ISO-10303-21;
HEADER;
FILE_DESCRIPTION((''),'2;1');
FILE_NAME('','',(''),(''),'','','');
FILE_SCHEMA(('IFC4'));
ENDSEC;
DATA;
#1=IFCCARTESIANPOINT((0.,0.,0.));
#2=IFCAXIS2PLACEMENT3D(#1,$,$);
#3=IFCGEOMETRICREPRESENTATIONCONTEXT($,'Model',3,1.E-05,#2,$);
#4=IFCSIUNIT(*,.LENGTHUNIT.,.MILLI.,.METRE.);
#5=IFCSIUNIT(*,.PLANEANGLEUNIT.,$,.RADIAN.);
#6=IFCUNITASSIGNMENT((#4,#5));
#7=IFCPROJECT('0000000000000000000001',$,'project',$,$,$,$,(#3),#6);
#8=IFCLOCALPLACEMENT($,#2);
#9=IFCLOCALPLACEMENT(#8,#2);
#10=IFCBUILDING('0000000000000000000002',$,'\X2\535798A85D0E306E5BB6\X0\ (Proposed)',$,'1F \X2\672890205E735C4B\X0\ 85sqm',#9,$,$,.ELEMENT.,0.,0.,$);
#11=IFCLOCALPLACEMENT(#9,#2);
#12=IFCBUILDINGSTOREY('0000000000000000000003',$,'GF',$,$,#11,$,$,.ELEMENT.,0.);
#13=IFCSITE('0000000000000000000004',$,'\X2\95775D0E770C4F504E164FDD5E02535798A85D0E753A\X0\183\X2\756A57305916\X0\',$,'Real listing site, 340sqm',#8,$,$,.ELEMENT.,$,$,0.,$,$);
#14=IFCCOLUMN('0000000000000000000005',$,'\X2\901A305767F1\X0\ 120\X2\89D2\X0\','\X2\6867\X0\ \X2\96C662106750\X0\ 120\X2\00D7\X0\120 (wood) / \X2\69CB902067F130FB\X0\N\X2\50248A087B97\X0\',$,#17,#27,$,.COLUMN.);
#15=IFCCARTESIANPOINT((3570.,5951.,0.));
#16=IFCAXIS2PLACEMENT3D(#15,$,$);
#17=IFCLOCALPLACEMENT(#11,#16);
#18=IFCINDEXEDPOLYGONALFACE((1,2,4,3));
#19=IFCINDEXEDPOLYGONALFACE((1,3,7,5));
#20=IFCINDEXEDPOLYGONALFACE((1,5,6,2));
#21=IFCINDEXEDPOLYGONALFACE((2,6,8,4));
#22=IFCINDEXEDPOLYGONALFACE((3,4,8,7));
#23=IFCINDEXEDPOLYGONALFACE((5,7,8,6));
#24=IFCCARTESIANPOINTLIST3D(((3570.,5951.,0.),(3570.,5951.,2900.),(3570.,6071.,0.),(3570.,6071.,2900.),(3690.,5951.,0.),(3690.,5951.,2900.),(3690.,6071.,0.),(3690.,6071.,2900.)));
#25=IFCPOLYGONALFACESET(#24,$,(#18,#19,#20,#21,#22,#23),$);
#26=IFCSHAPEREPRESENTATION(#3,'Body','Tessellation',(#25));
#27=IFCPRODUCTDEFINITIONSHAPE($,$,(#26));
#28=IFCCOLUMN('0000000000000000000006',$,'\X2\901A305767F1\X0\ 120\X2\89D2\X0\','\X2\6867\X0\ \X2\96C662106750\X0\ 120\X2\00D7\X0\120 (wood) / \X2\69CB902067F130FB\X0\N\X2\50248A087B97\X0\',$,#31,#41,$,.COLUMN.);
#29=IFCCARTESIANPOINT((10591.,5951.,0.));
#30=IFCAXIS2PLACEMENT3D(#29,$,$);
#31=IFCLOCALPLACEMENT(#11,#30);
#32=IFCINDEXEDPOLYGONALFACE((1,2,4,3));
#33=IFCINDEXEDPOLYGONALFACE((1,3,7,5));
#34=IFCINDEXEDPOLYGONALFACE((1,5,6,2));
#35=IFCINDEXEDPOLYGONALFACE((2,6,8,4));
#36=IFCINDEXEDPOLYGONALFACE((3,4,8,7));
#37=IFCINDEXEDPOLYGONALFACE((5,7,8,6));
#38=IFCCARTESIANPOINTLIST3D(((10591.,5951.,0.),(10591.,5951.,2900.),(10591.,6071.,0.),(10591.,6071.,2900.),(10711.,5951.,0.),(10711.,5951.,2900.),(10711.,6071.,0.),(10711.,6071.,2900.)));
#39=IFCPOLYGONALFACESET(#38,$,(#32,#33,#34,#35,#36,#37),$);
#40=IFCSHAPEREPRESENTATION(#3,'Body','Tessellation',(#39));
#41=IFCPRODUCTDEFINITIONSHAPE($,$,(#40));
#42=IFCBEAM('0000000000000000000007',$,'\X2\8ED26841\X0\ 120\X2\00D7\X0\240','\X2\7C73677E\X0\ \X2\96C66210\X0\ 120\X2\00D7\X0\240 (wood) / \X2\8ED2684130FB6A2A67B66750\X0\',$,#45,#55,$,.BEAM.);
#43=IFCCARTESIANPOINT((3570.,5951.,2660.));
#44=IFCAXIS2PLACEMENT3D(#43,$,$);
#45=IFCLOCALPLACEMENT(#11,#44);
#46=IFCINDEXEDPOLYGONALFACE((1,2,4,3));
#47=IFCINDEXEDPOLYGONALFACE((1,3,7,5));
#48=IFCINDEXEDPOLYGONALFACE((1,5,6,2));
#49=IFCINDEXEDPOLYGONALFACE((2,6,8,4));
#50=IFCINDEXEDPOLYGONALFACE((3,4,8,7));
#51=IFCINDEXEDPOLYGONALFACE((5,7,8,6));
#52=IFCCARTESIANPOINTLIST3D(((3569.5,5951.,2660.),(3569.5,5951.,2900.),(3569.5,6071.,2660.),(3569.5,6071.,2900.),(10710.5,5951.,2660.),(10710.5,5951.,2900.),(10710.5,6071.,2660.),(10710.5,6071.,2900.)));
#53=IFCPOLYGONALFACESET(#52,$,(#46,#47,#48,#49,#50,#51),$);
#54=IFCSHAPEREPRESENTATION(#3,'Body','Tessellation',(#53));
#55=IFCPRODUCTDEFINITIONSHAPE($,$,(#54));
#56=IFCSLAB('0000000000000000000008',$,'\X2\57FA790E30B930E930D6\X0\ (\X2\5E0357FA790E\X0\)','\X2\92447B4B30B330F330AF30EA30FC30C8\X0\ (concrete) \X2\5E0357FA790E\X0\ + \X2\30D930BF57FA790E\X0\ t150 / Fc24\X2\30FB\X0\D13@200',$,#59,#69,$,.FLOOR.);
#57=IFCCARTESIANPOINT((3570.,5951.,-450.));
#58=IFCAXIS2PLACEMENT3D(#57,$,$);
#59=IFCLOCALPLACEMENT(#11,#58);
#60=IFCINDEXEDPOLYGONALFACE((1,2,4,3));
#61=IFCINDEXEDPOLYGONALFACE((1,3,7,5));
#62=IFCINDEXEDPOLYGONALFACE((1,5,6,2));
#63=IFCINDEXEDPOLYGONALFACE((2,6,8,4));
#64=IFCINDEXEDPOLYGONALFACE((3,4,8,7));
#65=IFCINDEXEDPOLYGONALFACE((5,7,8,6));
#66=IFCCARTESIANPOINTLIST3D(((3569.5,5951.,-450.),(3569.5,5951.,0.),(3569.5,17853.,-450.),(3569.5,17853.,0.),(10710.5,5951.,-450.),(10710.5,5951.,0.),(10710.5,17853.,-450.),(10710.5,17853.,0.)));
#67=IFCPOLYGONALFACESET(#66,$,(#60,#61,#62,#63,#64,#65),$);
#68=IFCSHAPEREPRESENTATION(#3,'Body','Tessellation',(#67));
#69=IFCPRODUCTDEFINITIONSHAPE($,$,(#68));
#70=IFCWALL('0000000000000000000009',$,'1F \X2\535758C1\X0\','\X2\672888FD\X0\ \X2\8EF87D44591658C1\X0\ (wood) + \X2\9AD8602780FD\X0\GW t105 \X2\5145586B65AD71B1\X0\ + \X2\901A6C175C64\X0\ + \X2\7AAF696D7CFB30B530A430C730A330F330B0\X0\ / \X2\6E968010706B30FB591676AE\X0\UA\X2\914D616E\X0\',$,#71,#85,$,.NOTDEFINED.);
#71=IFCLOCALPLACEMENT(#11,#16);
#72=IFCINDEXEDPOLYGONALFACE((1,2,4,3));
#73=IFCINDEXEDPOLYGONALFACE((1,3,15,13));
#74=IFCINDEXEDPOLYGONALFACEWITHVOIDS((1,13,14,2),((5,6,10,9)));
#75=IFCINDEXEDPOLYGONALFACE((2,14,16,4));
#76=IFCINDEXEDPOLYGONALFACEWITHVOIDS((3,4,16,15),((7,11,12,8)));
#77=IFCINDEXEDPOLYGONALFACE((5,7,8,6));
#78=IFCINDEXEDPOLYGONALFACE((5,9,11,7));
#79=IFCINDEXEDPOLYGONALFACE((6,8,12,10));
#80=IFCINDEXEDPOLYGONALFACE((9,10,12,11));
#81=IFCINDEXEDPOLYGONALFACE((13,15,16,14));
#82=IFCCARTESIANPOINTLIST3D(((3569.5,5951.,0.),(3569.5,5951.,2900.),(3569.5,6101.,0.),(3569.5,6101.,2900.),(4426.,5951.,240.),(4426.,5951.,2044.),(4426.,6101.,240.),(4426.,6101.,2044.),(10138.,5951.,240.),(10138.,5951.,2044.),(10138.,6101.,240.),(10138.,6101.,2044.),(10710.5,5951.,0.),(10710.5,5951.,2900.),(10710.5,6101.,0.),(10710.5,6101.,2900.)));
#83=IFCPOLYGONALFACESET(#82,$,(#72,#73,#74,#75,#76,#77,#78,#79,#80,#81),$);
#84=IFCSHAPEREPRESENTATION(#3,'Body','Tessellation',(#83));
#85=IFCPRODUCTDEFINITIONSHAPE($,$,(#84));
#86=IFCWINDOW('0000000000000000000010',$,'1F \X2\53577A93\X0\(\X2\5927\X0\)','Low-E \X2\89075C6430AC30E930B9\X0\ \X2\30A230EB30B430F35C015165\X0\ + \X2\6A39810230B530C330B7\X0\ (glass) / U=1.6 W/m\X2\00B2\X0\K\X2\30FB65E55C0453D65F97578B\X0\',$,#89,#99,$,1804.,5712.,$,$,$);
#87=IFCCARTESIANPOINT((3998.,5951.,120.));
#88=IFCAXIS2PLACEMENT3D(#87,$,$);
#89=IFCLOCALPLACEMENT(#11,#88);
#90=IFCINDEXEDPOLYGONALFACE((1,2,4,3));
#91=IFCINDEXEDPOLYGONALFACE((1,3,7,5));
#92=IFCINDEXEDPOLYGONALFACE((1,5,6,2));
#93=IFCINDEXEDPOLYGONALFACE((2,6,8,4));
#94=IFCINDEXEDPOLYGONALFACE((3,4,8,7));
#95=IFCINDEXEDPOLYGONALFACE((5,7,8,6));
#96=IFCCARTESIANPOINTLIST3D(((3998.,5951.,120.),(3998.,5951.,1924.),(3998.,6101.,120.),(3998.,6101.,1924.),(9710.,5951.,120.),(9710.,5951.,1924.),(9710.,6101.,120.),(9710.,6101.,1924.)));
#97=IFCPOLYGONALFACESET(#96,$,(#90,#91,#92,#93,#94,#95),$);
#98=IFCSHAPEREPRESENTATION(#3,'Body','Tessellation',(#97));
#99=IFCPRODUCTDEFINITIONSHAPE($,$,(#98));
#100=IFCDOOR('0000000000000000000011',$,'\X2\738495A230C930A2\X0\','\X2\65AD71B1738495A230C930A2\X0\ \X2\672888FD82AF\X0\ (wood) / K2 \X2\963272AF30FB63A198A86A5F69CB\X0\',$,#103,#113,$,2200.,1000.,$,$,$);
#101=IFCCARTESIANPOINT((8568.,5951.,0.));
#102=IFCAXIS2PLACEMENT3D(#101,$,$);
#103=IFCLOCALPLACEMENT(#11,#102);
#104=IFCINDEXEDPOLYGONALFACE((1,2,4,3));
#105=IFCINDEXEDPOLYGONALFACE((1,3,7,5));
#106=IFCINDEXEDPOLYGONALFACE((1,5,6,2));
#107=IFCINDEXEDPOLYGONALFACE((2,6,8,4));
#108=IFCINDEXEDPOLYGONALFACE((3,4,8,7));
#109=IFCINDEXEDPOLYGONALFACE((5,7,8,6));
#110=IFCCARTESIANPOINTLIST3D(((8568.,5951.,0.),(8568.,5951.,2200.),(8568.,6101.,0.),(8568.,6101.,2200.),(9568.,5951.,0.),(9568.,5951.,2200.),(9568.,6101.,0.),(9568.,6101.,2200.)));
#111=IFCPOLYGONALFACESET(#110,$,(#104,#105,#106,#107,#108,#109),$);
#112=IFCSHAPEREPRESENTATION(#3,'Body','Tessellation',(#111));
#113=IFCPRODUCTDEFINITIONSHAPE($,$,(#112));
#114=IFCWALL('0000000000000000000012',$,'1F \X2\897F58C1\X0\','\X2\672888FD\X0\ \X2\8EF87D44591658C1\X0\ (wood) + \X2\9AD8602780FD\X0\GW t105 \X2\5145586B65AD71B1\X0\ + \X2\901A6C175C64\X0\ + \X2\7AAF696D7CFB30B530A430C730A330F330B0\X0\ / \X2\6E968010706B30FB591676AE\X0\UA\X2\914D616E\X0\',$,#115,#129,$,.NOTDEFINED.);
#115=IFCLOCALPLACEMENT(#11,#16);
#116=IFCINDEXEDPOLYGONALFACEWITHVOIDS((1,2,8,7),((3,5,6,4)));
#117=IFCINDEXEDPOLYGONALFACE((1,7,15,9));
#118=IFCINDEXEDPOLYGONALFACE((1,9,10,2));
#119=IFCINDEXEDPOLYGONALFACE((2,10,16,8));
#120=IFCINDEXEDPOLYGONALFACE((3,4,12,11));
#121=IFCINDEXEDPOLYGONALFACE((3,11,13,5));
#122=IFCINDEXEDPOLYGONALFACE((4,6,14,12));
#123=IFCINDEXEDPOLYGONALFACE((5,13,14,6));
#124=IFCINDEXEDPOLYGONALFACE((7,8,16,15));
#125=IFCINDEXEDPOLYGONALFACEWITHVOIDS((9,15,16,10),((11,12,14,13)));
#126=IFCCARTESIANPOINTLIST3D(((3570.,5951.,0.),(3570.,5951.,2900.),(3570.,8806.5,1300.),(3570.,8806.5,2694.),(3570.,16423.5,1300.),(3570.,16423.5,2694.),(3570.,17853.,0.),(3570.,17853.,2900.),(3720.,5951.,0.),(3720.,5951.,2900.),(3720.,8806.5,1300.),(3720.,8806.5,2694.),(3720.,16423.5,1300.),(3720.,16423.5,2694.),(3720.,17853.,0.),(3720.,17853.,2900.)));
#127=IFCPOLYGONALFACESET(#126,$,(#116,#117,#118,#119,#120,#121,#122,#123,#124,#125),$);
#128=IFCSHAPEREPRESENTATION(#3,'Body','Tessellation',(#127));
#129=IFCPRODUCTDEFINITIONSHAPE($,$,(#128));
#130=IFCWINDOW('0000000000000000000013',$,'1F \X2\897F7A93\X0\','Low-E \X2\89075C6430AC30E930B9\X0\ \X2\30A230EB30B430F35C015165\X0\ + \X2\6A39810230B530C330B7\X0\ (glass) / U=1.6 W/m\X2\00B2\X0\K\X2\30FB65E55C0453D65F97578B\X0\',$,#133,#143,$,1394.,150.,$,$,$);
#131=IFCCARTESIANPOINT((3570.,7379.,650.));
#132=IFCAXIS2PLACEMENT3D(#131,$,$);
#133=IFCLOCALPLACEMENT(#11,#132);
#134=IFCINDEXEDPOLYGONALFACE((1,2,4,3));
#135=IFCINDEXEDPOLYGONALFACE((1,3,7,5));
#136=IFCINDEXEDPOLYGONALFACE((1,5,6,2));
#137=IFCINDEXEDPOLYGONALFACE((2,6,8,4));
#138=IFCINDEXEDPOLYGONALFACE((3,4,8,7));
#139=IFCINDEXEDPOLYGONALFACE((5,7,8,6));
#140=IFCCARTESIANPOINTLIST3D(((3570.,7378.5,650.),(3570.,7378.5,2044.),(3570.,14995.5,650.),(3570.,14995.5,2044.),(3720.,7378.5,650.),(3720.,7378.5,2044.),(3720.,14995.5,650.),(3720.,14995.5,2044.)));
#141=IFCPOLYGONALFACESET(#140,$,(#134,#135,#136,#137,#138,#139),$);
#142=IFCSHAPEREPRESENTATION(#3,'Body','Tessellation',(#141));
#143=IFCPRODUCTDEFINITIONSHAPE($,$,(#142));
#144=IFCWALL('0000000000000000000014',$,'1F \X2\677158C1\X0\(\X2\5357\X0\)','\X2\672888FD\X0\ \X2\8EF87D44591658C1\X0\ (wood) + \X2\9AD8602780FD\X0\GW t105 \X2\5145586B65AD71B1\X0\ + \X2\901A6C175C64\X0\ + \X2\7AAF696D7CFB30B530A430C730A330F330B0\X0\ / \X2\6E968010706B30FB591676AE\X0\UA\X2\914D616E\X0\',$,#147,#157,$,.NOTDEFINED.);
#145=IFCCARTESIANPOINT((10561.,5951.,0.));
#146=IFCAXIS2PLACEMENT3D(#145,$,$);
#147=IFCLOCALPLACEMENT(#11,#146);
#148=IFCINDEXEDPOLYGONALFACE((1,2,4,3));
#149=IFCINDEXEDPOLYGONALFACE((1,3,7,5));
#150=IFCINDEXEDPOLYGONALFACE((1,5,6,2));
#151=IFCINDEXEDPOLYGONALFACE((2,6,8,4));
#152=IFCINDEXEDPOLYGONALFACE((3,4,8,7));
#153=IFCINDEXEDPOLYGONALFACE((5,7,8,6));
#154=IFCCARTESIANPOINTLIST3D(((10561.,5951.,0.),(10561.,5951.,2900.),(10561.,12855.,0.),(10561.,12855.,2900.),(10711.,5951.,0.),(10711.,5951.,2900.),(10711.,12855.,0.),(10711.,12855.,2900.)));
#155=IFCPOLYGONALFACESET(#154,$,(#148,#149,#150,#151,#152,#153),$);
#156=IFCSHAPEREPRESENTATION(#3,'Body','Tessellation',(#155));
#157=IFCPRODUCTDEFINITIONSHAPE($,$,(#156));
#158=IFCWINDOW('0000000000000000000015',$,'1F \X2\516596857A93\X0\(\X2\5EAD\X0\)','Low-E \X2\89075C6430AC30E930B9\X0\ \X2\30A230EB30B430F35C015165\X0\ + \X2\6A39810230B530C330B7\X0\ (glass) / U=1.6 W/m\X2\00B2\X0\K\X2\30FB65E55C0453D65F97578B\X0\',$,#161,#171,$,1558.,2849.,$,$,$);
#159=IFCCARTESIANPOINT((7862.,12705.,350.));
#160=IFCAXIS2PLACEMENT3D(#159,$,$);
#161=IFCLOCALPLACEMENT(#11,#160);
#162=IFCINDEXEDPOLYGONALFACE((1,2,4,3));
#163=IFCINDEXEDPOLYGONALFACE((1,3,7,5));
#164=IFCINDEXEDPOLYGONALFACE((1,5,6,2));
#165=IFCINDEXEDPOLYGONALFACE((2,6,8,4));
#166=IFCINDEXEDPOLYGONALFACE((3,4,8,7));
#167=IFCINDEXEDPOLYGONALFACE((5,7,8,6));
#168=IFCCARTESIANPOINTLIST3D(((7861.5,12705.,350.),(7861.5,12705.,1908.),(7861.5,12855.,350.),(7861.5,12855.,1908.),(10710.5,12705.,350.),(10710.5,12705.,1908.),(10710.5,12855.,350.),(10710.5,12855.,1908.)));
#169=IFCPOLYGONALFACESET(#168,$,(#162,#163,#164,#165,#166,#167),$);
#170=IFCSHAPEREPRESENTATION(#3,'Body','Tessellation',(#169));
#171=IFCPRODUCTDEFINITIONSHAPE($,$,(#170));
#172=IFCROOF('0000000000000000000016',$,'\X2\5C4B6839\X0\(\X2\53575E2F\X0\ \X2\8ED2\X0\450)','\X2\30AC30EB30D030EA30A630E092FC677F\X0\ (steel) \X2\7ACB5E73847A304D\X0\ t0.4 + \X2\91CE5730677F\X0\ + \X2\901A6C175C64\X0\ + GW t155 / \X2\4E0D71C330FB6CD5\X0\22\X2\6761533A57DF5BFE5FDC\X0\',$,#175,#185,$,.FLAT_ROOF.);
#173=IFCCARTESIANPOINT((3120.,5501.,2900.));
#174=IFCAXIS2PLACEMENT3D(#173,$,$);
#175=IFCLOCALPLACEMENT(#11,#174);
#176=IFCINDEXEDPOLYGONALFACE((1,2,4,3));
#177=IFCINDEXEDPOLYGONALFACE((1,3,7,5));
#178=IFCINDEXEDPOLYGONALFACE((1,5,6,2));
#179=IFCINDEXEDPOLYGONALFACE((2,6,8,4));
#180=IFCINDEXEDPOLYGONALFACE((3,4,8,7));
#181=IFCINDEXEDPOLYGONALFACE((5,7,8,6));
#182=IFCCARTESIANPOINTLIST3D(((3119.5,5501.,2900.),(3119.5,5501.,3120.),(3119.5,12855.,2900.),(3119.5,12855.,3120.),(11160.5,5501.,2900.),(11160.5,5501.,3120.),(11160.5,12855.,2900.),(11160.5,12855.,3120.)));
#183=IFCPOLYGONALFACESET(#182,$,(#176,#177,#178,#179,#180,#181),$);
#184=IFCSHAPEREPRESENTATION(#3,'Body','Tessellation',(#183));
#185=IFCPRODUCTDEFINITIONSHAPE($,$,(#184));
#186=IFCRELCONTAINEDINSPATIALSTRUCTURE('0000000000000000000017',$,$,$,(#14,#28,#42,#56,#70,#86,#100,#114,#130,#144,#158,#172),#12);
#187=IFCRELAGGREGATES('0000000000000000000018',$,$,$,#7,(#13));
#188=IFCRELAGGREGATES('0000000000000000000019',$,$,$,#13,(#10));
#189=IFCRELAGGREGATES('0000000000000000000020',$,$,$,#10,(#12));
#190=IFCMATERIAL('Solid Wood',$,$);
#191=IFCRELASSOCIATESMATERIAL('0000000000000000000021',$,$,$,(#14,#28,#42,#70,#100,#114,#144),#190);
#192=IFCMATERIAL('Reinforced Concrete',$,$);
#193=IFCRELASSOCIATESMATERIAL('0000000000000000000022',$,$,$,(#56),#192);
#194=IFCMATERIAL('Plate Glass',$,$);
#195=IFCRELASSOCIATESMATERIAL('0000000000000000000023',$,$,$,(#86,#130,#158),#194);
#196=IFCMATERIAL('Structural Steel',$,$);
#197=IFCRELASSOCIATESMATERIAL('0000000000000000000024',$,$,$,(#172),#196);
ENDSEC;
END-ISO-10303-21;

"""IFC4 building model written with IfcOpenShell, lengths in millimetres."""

from ifc_helpers import new_model, si_unit, frame, frame_2d, origin, place, context, project, spatial, rectangle, extrude, material, element, fill, save


model = new_model("IFC4")

# Units and contexts
model_context = context("Model", 3, precision=1e-05, world=origin())
ifc_project = project(units=[si_unit("LENGTHUNIT", "METRE", prefix="MILLI"), si_unit("PLANEANGLEUNIT", "RADIAN")], contexts=[model_context])

# Site, building, storey
site_placement = place(None, origin())
site = spatial("IfcSite", under=ifc_project, at=site_placement, Name="長崎県佐世保市南風崎町183番地外", ObjectType="Real listing site, 340sqm", CompositionType="ELEMENT", RefElevation=0.0)
building_placement = place(site_placement, origin())
building = spatial("IfcBuilding", under=site, at=building_placement, Name="南風崎の家 (Proposed)", ObjectType="1F 木造平屋 85sqm", CompositionType="ELEMENT", ElevationOfRefHeight=0.0, ElevationOfTerrain=0.0)
storey_placement = place(building_placement, origin())
storey = spatial("IfcBuildingStorey", under=building, at=storey_placement, Name="GF", CompositionType="ELEMENT", Elevation=0.0)

# Columns
ifc_material_1 = material(Name="Solid Wood")
column_1_placement = place(storey_placement, frame((3570.0, 5951.0, 0.0)))
element("IfcColumn", 1, at=column_1_placement, inside=storey, material=ifc_material_1, Name="通し柱 120角", Description="桧 集成材 120×120 (wood) / 構造柱・N値計算", PredefinedType="COLUMN", context=model_context, shape_type="SweptSolid", body=[
    extrude(rectangle(XDim=120.0, YDim=120.0, at=frame_2d((60.0, 60.0))), frame((3570.0, 5951.0, 0.0)), (0.0, 0.0, 1.0), 2900.0),
])
column_2_placement = place(storey_placement, frame((10591.0, 5951.0, 0.0)))
element("IfcColumn", 2, at=column_2_placement, inside=storey, material=ifc_material_1, Name="通し柱 120角", Description="桧 集成材 120×120 (wood) / 構造柱・N値計算", PredefinedType="COLUMN", context=model_context, shape_type="SweptSolid", body=[
    extrude(rectangle(XDim=120.0, YDim=120.0, at=frame_2d((60.0, 60.0))), frame((10591.0, 5951.0, 0.0)), (0.0, 0.0, 1.0), 2900.0),
])

# Beam
beam_1_placement = place(storey_placement, frame((3570.0, 5951.0, 2660.0)))
element("IfcBeam", 3, at=beam_1_placement, inside=storey, material=ifc_material_1, Name="軒桁 120×240", Description="米松 集成 120×240 (wood) / 軒桁・横架材", PredefinedType="BEAM", context=model_context, shape_type="SweptSolid", body=[
    extrude(rectangle(XDim=7141.0, YDim=120.0, at=frame_2d((3570.0, 60.0))), frame((3570.0, 5951.0, 2660.0)), (0.0, 0.0, 1.0), 240.0),
])

# Slab
ifc_material_2 = material(Name="Reinforced Concrete")
slab_1_placement = place(storey_placement, frame((3570.0, 5951.0, -450.0)))
element("IfcSlab", 4, at=slab_1_placement, inside=storey, material=ifc_material_2, Name="基礎スラブ (布基礎)", Description="鉄筋コンクリート (concrete) 布基礎 + ベタ基礎 t150 / Fc24・D13@200", PredefinedType="FLOOR", context=model_context, shape_type="SweptSolid", body=[
    extrude(rectangle(XDim=7141.0, YDim=11902.0, at=frame_2d((3570.0, 5951.0))), frame((3570.0, 5951.0, -450.0)), (0.0, 0.0, 1.0), 450.0),
])

# Wall, openings, window, door
wall_1_placement = place(storey_placement, frame((3570.0, 5951.0, 0.0)))
wall_1 = element("IfcWall", 5, at=wall_1_placement, inside=storey, material=ifc_material_1, Name="1F 南壁", Description="木製 軸組外壁 (wood) + 高性能GW t105 充填断熱 + 通気層 + 窯業系サイディング / 準耐火・外皮UA配慮", PredefinedType="NOTDEFINED", context=model_context, shape_type="SweptSolid", body=[
    extrude(rectangle(XDim=7141.0, YDim=150.0, at=frame_2d((3570.0, 75.0))), frame((3570.0, 5951.0, 0.0)), (0.0, 0.0, 1.0), 2900.0),
])
opening_1_placement = place(storey_placement, frame((3998.0, 5951.0, 120.0)))
opening_1 = element("IfcOpeningElement", 6, at=opening_1_placement, cuts=wall_1, PredefinedType="NOTDEFINED", context=model_context, shape_type="SweptSolid", body=[
    extrude(rectangle(XDim=5712.0, YDim=150.0, at=frame_2d((2856.0, 75.0))), frame((3998.0, 5951.0, 120.0)), (0.0, 0.0, 1.0), 1804.0),
])
opening_2_placement = place(storey_placement, frame((8568.0, 5951.0, 0.0)))
opening_2 = element("IfcOpeningElement", 7, at=opening_2_placement, cuts=wall_1, PredefinedType="NOTDEFINED", context=model_context, shape_type="SweptSolid", body=[
    extrude(rectangle(XDim=1000.0, YDim=150.0, at=frame_2d((500.0, 75.0))), frame((8568.0, 5951.0, 0.0)), (0.0, 0.0, 1.0), 2200.0),
])
ifc_material_3 = material(Name="Plate Glass")
window_1_placement = place(storey_placement, frame((3998.0, 5951.0, 120.0)))
window_1 = element("IfcWindow", 8, at=window_1_placement, inside=storey, material=ifc_material_3, Name="1F 南窓(大)", Description="Low-E 複層ガラス アルゴン封入 + 樹脂サッシ (glass) / U=1.6 W/m²K・日射取得型", OverallHeight=1804.0, OverallWidth=5712.0, context=model_context, shape_type="SweptSolid", body=[
    extrude(rectangle(XDim=5712.0, YDim=150.0, at=frame_2d((2856.0, 75.0))), frame((3998.0, 5951.0, 120.0)), (0.0, 0.0, 1.0), 1804.0),
])
fill(opening_1, window_1)
door_1_placement = place(storey_placement, frame((8568.0, 5951.0, 0.0)))
door_1 = element("IfcDoor", 9, at=door_1_placement, inside=storey, material=ifc_material_1, Name="玄関ドア", Description="断熱玄関ドア 木製芯 (wood) / K2 防犯・採風機構", OverallHeight=2200.0, OverallWidth=1000.0, context=model_context, shape_type="SweptSolid", body=[
    extrude(rectangle(XDim=1000.0, YDim=150.0, at=frame_2d((500.0, 75.0))), frame((8568.0, 5951.0, 0.0)), (0.0, 0.0, 1.0), 2200.0),
])
fill(opening_2, door_1)

# Walls, openings, windows
wall_2_placement = place(storey_placement, frame((3570.0, 5951.0, 0.0)))
wall_2 = element("IfcWall", 10, at=wall_2_placement, inside=storey, material=ifc_material_1, Name="1F 西壁", Description="木製 軸組外壁 (wood) + 高性能GW t105 充填断熱 + 通気層 + 窯業系サイディング / 準耐火・外皮UA配慮", PredefinedType="NOTDEFINED", context=model_context, shape_type="SweptSolid", body=[
    extrude(rectangle(XDim=150.0, YDim=11902.0, at=frame_2d((75.0, 5951.0))), frame((3570.0, 5951.0, 0.0)), (0.0, 0.0, 1.0), 2900.0),
])
opening_3_placement = place(storey_placement, frame((3570.0, 7379.0, 650.0)))
opening_3 = element("IfcOpeningElement", 11, at=opening_3_placement, cuts=wall_2, PredefinedType="NOTDEFINED", context=model_context, shape_type="SweptSolid", body=[
    extrude(rectangle(XDim=150.0, YDim=7617.0, at=frame_2d((75.0, 3808.0))), frame((3570.0, 7379.0, 650.0)), (0.0, 0.0, 1.0), 1394.0),
])
window_2_placement = place(storey_placement, frame((3570.0, 7379.0, 650.0)))
window_2 = element("IfcWindow", 12, at=window_2_placement, inside=storey, material=ifc_material_3, Name="1F 西窓", Description="Low-E 複層ガラス アルゴン封入 + 樹脂サッシ (glass) / U=1.6 W/m²K・日射取得型", OverallHeight=1394.0, OverallWidth=150.0, context=model_context, shape_type="SweptSolid", body=[
    extrude(rectangle(XDim=150.0, YDim=7617.0, at=frame_2d((75.0, 3808.0))), frame((3570.0, 7379.0, 650.0)), (0.0, 0.0, 1.0), 1394.0),
])
fill(opening_3, window_2)
wall_3_placement = place(storey_placement, frame((10561.0, 5951.0, 0.0)))
wall_3 = element("IfcWall", 13, at=wall_3_placement, inside=storey, material=ifc_material_1, Name="1F 東壁(南)", Description="木製 軸組外壁 (wood) + 高性能GW t105 充填断熱 + 通気層 + 窯業系サイディング / 準耐火・外皮UA配慮", PredefinedType="NOTDEFINED", context=model_context, shape_type="SweptSolid", body=[
    extrude(rectangle(XDim=150.0, YDim=6904.0, at=frame_2d((75.0, 3452.0))), frame((10561.0, 5951.0, 0.0)), (0.0, 0.0, 1.0), 2900.0),
])
opening_4_placement = place(storey_placement, frame((7862.0, 12705.0, 350.0)))
opening_4 = element("IfcOpeningElement", 14, at=opening_4_placement, cuts=wall_3, PredefinedType="NOTDEFINED", context=model_context, shape_type="SweptSolid", body=[
    extrude(rectangle(XDim=2849.0, YDim=150.0, at=frame_2d((1424.0, 75.0))), frame((7862.0, 12705.0, 350.0)), (0.0, 0.0, 1.0), 1558.0),
])
window_3_placement = place(storey_placement, frame((7862.0, 12705.0, 350.0)))
window_3 = element("IfcWindow", 15, at=window_3_placement, inside=storey, material=ifc_material_3, Name="1F 入隅窓(庭)", Description="Low-E 複層ガラス アルゴン封入 + 樹脂サッシ (glass) / U=1.6 W/m²K・日射取得型", OverallHeight=1558.0, OverallWidth=2849.0, context=model_context, shape_type="SweptSolid", body=[
    extrude(rectangle(XDim=2849.0, YDim=150.0, at=frame_2d((1424.0, 75.0))), frame((7862.0, 12705.0, 350.0)), (0.0, 0.0, 1.0), 1558.0),
])
fill(opening_4, window_3)

# Roof
ifc_material_4 = material(Name="Structural Steel")
roof_placement = place(storey_placement, frame((3120.0, 5501.0, 2900.0)))
element("IfcRoof", 16, at=roof_placement, inside=storey, material=ifc_material_4, Name="屋根(南帯 軒450)", Description="ガルバリウム鋼板 (steel) 立平葺き t0.4 + 野地板 + 通気層 + GW t155 / 不燃・法22条区域対応", PredefinedType="FLAT_ROOF", context=model_context, shape_type="SweptSolid", body=[
    extrude(rectangle(XDim=8041.0, YDim=7354.0, at=frame_2d((4020.0, 3677.0))), frame((3120.0, 5501.0, 2900.0)), (0.0, 0.0, 1.0), 220.0),
])

save(model, "model.ifc")
